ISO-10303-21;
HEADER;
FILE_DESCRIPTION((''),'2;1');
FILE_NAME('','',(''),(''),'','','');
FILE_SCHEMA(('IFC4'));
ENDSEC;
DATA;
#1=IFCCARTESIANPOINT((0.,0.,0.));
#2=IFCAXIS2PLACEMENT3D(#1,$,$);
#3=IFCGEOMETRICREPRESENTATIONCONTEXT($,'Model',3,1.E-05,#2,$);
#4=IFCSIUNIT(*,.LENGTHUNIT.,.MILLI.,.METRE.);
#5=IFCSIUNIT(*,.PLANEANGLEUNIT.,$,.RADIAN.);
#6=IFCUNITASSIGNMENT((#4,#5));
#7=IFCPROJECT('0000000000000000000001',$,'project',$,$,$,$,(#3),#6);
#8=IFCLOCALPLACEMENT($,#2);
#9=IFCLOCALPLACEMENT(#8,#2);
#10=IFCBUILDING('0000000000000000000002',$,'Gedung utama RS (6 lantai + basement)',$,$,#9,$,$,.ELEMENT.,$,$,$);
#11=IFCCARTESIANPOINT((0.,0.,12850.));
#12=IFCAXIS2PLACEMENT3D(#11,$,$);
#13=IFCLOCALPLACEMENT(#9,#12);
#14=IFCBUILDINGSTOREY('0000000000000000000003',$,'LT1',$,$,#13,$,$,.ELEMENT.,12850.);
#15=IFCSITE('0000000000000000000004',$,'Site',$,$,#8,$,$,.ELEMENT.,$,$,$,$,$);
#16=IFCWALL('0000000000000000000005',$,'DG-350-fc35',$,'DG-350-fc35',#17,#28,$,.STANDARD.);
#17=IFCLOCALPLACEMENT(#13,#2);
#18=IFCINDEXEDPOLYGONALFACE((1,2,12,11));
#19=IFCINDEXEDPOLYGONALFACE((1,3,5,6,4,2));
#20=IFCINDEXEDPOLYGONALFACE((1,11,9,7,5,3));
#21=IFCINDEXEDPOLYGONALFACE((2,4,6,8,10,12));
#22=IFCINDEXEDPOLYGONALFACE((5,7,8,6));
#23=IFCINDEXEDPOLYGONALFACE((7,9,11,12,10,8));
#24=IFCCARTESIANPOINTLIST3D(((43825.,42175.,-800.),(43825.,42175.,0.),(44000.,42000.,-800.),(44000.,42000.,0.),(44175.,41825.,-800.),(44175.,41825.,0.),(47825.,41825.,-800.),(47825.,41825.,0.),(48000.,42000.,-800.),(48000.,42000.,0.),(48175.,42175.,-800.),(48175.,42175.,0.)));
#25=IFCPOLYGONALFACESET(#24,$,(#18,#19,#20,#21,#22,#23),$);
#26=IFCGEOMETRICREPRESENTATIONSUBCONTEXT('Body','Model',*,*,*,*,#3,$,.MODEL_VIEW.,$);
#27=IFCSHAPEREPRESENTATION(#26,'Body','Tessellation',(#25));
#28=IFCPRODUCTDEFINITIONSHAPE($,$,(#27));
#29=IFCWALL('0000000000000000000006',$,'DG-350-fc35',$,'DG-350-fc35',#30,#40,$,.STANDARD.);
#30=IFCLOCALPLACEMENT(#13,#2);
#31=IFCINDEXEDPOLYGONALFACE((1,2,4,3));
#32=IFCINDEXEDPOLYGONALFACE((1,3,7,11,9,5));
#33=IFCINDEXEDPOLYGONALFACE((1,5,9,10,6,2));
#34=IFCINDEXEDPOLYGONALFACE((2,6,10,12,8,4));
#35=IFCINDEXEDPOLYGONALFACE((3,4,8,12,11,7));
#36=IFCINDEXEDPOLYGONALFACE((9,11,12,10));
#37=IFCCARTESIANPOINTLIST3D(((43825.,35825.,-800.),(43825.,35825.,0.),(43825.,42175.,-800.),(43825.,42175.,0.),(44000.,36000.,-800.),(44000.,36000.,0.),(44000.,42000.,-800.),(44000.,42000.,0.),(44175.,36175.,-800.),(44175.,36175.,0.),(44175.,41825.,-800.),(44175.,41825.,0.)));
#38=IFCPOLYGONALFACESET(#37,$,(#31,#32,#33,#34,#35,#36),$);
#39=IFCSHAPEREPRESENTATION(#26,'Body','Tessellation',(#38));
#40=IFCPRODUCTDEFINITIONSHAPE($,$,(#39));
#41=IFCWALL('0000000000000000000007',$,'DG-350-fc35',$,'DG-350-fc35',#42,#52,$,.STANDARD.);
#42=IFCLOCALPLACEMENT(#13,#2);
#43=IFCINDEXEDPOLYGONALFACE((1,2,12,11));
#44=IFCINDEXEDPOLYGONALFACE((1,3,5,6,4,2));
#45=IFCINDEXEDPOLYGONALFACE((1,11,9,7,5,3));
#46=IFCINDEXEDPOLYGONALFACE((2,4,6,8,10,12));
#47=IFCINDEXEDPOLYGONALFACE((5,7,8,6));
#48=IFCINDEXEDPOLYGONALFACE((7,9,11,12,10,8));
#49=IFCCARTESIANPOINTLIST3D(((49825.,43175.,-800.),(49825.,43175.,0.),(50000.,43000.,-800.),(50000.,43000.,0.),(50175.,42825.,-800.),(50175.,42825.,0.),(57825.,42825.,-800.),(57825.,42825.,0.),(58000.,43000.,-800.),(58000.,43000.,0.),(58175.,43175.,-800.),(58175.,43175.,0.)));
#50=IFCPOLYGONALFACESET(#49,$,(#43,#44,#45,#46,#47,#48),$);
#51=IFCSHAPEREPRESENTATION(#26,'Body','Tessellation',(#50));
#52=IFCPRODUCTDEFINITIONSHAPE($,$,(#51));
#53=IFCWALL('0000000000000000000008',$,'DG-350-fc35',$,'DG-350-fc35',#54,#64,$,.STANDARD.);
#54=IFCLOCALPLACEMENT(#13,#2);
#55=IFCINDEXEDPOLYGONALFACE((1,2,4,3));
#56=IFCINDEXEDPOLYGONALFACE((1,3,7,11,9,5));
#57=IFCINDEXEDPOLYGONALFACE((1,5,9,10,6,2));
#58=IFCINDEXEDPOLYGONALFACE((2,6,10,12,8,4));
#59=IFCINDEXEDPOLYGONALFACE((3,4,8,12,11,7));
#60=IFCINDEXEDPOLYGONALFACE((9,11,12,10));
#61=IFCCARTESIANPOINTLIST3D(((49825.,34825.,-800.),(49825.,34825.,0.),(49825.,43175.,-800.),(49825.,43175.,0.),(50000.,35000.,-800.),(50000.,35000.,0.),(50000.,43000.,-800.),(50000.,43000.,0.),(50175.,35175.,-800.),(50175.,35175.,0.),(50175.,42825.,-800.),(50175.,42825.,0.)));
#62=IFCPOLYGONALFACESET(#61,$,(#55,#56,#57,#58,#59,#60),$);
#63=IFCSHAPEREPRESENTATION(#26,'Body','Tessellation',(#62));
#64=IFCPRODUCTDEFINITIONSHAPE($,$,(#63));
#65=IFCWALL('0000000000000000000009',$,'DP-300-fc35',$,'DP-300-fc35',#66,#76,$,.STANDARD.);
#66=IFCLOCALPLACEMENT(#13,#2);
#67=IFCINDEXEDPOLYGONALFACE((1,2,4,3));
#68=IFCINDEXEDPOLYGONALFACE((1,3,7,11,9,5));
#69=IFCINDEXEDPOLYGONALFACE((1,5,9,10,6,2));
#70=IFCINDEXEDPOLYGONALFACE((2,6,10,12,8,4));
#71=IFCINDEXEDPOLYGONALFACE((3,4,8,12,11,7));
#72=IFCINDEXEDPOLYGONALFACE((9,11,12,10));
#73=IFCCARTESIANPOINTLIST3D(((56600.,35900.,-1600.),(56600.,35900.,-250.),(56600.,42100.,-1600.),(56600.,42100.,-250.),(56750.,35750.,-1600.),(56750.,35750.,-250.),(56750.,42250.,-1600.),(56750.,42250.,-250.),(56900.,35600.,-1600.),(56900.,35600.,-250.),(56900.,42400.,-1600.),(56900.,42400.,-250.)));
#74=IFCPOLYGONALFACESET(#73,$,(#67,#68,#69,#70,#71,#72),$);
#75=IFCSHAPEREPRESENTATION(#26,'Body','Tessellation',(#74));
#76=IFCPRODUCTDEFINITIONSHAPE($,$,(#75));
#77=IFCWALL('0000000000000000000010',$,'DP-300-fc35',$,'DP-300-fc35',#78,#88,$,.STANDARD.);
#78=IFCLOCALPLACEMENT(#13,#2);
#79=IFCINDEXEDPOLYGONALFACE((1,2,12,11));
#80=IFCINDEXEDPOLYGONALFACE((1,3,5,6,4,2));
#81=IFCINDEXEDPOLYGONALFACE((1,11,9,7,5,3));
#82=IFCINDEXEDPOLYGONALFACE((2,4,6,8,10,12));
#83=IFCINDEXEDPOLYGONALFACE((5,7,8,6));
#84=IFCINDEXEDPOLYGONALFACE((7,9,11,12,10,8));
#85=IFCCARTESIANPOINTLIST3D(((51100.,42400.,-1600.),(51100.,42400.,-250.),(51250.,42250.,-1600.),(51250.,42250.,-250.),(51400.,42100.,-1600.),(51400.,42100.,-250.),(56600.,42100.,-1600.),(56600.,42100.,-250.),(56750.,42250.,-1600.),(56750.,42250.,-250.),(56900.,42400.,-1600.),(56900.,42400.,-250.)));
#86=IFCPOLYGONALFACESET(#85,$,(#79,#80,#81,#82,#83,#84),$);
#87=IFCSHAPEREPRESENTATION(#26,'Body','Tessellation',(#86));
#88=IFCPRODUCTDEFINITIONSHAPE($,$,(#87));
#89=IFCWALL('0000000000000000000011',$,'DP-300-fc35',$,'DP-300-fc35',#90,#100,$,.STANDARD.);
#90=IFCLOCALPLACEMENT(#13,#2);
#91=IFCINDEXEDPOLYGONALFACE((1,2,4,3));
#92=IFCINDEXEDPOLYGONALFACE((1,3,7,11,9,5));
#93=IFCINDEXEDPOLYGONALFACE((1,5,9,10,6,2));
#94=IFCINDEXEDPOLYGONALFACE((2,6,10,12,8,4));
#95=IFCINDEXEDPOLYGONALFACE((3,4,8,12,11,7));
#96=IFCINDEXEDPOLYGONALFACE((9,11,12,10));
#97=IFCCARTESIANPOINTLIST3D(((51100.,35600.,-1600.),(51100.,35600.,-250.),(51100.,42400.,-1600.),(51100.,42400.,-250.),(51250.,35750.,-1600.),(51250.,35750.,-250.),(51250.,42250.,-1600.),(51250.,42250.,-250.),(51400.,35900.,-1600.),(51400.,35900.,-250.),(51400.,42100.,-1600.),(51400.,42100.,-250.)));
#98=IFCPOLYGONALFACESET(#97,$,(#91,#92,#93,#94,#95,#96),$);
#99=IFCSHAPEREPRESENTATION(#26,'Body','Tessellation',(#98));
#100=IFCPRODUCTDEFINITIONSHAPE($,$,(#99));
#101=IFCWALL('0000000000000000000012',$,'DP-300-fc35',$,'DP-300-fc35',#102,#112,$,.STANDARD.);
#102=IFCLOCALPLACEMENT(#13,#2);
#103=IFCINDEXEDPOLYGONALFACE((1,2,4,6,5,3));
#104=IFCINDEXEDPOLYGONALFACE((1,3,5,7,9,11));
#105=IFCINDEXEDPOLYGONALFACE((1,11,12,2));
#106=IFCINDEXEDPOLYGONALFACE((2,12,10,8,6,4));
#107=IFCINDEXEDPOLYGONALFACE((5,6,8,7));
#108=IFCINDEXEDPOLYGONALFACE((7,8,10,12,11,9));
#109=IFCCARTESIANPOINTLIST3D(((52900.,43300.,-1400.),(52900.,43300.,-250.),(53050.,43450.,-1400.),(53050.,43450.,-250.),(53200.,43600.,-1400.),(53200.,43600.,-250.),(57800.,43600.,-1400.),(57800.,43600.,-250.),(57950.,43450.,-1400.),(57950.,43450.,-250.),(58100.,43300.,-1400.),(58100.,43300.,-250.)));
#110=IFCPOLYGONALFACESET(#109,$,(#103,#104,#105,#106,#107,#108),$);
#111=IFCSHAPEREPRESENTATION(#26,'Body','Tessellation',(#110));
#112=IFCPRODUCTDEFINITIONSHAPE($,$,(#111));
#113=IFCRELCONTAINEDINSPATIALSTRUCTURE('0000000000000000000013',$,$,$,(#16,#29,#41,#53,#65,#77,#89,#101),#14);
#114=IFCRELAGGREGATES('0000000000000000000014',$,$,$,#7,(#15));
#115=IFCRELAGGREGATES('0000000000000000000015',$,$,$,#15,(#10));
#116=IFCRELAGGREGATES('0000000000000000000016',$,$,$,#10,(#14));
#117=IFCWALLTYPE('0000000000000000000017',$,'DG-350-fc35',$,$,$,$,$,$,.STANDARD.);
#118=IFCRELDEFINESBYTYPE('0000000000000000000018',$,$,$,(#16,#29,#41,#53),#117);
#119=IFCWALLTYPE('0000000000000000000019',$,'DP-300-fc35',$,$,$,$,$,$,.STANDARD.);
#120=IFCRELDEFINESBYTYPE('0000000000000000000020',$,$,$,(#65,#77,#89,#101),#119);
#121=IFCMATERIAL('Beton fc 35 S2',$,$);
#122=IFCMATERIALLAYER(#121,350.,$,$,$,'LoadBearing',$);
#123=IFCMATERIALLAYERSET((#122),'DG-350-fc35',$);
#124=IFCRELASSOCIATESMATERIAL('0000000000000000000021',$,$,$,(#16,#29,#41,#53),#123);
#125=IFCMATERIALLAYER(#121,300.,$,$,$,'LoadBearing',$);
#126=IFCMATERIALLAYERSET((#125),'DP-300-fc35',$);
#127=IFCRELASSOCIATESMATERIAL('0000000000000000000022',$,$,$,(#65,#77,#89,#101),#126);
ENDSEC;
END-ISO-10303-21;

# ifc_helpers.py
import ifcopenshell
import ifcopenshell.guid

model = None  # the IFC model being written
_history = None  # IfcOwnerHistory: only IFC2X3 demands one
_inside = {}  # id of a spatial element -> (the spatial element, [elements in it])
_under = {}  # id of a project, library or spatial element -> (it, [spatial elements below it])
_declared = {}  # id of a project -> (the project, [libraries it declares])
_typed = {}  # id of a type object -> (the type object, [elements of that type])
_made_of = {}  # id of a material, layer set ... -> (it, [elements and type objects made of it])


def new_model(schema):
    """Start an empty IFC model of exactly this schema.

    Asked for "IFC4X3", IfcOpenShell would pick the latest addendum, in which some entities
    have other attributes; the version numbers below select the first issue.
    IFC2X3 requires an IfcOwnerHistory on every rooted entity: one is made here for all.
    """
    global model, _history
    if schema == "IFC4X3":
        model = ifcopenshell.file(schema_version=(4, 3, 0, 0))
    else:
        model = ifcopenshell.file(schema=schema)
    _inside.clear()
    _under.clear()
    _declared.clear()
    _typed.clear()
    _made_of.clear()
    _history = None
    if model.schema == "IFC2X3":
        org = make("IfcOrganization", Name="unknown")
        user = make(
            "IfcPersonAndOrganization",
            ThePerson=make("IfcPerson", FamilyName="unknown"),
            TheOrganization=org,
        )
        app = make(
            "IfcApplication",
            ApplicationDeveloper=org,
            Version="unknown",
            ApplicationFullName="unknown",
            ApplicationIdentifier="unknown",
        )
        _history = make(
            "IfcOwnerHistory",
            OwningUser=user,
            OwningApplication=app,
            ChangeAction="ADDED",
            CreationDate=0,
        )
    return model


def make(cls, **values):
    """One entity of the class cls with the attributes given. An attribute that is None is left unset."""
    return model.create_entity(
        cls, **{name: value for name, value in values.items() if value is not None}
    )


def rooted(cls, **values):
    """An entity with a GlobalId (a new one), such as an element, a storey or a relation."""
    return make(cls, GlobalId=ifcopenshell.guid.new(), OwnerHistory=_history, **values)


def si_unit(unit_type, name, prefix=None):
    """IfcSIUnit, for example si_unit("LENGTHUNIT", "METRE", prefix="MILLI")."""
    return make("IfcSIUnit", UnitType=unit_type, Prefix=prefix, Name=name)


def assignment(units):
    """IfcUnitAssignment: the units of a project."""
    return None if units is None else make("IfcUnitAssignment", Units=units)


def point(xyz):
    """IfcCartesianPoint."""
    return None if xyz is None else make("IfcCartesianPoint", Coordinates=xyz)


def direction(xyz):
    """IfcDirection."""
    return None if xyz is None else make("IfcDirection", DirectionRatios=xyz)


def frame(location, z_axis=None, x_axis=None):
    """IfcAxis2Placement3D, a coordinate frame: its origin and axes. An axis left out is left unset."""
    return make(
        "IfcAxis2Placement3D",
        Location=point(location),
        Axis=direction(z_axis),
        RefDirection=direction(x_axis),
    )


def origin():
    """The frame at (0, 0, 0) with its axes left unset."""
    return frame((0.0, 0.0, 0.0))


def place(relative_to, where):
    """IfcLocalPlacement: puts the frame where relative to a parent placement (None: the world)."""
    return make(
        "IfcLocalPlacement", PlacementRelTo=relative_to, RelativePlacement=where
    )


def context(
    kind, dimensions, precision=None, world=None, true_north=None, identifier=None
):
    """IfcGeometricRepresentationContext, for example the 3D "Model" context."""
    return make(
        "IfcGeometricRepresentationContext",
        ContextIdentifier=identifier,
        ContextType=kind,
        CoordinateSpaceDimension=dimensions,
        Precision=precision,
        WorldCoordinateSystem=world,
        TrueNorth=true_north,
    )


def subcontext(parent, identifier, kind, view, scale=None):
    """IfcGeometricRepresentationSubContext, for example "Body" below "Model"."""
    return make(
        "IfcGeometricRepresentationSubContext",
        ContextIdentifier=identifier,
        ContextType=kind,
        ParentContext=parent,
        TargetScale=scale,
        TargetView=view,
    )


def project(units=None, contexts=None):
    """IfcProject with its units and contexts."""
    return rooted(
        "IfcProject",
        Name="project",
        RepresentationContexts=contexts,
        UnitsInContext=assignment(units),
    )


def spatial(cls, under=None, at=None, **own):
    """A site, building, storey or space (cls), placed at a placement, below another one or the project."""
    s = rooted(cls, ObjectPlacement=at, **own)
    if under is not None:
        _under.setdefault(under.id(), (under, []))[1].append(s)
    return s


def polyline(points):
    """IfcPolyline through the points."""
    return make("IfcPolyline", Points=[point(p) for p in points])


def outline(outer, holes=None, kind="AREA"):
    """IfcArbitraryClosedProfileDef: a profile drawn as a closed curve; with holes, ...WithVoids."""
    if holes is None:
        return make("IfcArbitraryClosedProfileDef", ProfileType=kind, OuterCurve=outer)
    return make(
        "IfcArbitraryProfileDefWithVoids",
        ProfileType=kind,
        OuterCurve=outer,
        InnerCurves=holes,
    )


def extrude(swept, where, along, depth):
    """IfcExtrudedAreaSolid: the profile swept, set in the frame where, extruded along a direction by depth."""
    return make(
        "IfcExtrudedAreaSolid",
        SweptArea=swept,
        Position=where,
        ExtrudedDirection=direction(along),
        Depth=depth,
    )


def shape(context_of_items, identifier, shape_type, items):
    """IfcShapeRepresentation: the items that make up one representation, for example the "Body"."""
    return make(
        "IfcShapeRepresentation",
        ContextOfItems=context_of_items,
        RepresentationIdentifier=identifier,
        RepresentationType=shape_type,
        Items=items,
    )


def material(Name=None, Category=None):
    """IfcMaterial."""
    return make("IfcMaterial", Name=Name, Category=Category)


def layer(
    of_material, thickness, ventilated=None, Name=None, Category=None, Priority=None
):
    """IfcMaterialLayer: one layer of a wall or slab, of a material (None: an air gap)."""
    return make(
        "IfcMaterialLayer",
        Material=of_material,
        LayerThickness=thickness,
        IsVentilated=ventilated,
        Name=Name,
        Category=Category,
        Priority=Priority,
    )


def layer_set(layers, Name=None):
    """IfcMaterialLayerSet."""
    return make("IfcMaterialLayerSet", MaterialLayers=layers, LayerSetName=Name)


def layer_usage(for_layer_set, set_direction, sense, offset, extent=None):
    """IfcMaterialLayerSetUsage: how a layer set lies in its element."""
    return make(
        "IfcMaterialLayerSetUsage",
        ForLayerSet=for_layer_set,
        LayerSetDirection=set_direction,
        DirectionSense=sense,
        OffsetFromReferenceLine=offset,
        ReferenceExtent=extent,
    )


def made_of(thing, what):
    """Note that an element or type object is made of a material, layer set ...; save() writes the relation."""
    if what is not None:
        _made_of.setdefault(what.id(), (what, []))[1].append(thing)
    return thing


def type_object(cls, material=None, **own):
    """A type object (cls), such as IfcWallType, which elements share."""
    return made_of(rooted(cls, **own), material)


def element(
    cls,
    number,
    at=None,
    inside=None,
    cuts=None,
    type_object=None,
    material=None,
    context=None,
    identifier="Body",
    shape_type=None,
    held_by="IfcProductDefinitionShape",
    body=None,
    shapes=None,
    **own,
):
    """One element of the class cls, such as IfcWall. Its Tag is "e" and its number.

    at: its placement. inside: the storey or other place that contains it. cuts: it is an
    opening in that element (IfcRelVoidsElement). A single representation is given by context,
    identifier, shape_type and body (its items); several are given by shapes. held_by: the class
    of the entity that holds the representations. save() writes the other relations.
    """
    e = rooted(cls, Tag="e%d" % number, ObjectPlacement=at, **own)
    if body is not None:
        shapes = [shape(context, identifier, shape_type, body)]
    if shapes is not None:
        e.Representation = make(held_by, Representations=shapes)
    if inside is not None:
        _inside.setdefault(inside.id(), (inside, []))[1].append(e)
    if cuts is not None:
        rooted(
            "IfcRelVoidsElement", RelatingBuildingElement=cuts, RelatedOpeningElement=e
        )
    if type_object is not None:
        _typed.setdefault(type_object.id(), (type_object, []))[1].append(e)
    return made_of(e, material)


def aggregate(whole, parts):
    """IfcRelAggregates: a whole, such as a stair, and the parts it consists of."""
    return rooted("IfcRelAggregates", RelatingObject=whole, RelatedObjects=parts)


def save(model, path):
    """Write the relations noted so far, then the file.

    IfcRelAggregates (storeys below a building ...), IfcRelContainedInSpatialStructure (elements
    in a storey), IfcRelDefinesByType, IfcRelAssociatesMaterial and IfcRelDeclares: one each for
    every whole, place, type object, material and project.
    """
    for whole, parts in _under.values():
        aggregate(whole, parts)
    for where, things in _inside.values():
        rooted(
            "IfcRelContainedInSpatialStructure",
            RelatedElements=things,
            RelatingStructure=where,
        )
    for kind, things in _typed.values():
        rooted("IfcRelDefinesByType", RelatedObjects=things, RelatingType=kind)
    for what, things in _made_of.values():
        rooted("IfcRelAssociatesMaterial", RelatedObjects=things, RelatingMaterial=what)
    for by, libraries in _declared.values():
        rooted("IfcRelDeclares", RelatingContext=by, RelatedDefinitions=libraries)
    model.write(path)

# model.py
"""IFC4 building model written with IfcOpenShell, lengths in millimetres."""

from ifc_helpers import new_model, si_unit, frame, origin, place, context, subcontext, project, spatial, polyline, outline, extrude, material, layer, layer_set, layer_usage, type_object, element, save


model = new_model("IFC4")

# Units and contexts
model_context = context("Model", 3, precision=1e-05, world=origin())
body_context = subcontext(model_context, "Body", "Model", "MODEL_VIEW")
ifc_project = project(units=[si_unit("LENGTHUNIT", "METRE", prefix="MILLI"), si_unit("PLANEANGLEUNIT", "RADIAN")], contexts=[model_context])

# Site, building, storey
site_placement = place(None, origin())
site = spatial("IfcSite", under=ifc_project, at=site_placement, Name="Site", CompositionType="ELEMENT")
building_placement = place(site_placement, origin())
building = spatial("IfcBuilding", under=site, at=building_placement, Name="Gedung utama RS (6 lantai + basement)", CompositionType="ELEMENT")
storey_placement = place(building_placement, frame((0.0, 0.0, 12850.0)))
storey = spatial("IfcBuildingStorey", under=building, at=storey_placement, Name="LT1", CompositionType="ELEMENT", Elevation=12850.0)

# Shared definitions
ifc_material = material(Name="Beton fc 35 S2")

# Walls
ifc_layer_1 = layer(ifc_material, 350.0, Category="LoadBearing")
ifc_layer_set_1 = layer_set([ifc_layer_1], Name="DG-350-fc35")
ifc_layer_usage_1 = layer_usage(ifc_layer_set_1, "AXIS2", "NEGATIVE", 175.0)
wall_type_1 = type_object("IfcWallType", Name="DG-350-fc35", PredefinedType="STANDARD")
wall_1_placement = place(storey_placement, frame((48000.0, 42000.0, -800.0), z_axis=(0.0, 0.0, 1.0), x_axis=(-1.0, 0.0, 0.0)))
element("IfcWall", 1, at=wall_1_placement, inside=storey, type_object=wall_type_1, material=ifc_layer_usage_1, Name="DG-350-fc35", ObjectType="DG-350-fc35", PredefinedType="STANDARD", context=body_context, shape_type="SweptSolid", body=[
    extrude(outline(polyline([(-175.0, -175.0), (0.0, 0.0), (175.0, 175.0), (3825.0, 175.0), (4000.0, 0.0), (4175.0, -175.0), (-175.0, -175.0)])), origin(), (0.0, 0.0, 1.0), 800.0),
])
wall_2_placement = place(storey_placement, frame((44000.0, 42000.0, -800.0), z_axis=(0.0, 0.0, 1.0), x_axis=(0.0, -1.0, 0.0)))
element("IfcWall", 2, at=wall_2_placement, inside=storey, type_object=wall_type_1, material=ifc_layer_usage_1, Name="DG-350-fc35", ObjectType="DG-350-fc35", PredefinedType="STANDARD", context=body_context, shape_type="SweptSolid", body=[
    extrude(outline(polyline([(-175.0, -175.0), (0.0, 0.0), (175.0, 175.0), (5825.0, 175.0), (6000.0, 0.0), (6175.0, -175.0), (-175.0, -175.0)])), origin(), (0.0, 0.0, 1.0), 800.0),
])
for number, where, z_axis, x_axis, name in (
    (3, (58000.0, 43000.0, -800.0), (0.0, 0.0, 1.0), (-1.0, 0.0, 0.0), "DG-350-fc35"),
    (4, (50000.0, 43000.0, -800.0), (0.0, 0.0, 1.0), (0.0, -1.0, 0.0), "DG-350-fc35"),
):
    element("IfcWall", number, at=place(storey_placement, frame(where, z_axis=z_axis, x_axis=x_axis)), inside=storey, type_object=wall_type_1, material=ifc_layer_usage_1, Name=name, ObjectType="DG-350-fc35", PredefinedType="STANDARD", context=body_context, shape_type="SweptSolid", body=[
        extrude(outline(polyline([(-175.0, -175.0), (0.0, 0.0), (175.0, 175.0), (7825.0, 175.0), (8000.0, 0.0), (8175.0, -175.0), (-175.0, -175.0)])), origin(), (0.0, 0.0, 1.0), 800.0),
    ])
ifc_layer_2 = layer(ifc_material, 300.0, Category="LoadBearing")
ifc_layer_set_2 = layer_set([ifc_layer_2], Name="DP-300-fc35")
ifc_layer_usage_2 = layer_usage(ifc_layer_set_2, "AXIS2", "NEGATIVE", 150.0)
wall_type_2 = type_object("IfcWallType", Name="DP-300-fc35", PredefinedType="STANDARD")
wall_3_placement = place(storey_placement, frame((56750.0, 35750.0, -1600.0), z_axis=(0.0, 0.0, 1.0), x_axis=(0.0, 1.0, 0.0)))
element("IfcWall", 5, at=wall_3_placement, inside=storey, type_object=wall_type_2, material=ifc_layer_usage_2, Name="DP-300-fc35", ObjectType="DP-300-fc35", PredefinedType="STANDARD", context=body_context, shape_type="SweptSolid", body=[
    extrude(outline(polyline([(-150.0, -150.0), (0.0, 0.0), (150.0, 150.0), (6350.0, 150.0), (6500.0, 0.0), (6650.0, -150.0), (-150.0, -150.0)])), origin(), (0.0, 0.0, 1.0), 1350.0),
])
wall_4_placement = place(storey_placement, frame((56750.0, 42250.0, -1600.0), z_axis=(0.0, 0.0, 1.0), x_axis=(-1.0, 0.0, 0.0)))
element("IfcWall", 6, at=wall_4_placement, inside=storey, type_object=wall_type_2, material=ifc_layer_usage_2, Name="DP-300-fc35", ObjectType="DP-300-fc35", PredefinedType="STANDARD", context=body_context, shape_type="SweptSolid", body=[
    extrude(outline(polyline([(-150.0, -150.0), (0.0, 0.0), (150.0, 150.0), (5350.0, 150.0), (5500.0, 0.0), (5650.0, -150.0), (-150.0, -150.0)])), origin(), (0.0, 0.0, 1.0), 1350.0),
])
wall_5_placement = place(storey_placement, frame((51250.0, 42250.0, -1600.0), z_axis=(0.0, 0.0, 1.0), x_axis=(0.0, -1.0, 0.0)))
element("IfcWall", 7, at=wall_5_placement, inside=storey, type_object=wall_type_2, material=ifc_layer_usage_2, Name="DP-300-fc35", ObjectType="DP-300-fc35", PredefinedType="STANDARD", context=body_context, shape_type="SweptSolid", body=[
    extrude(outline(polyline([(-150.0, -150.0), (0.0, 0.0), (150.0, 150.0), (6350.0, 150.0), (6500.0, 0.0), (6650.0, -150.0), (-150.0, -150.0)])), origin(), (0.0, 0.0, 1.0), 1350.0),
])
wall_6_placement = place(storey_placement, frame((53050.0, 43450.0, -1400.0), z_axis=(0.0, 0.0, 1.0), x_axis=(1.0, 0.0, 0.0)))
element("IfcWall", 8, at=wall_6_placement, inside=storey, type_object=wall_type_2, material=ifc_layer_usage_2, Name="DP-300-fc35", ObjectType="DP-300-fc35", PredefinedType="STANDARD", context=body_context, shape_type="SweptSolid", body=[
    extrude(outline(polyline([(-150.0, -150.0), (0.0, 0.0), (150.0, 150.0), (4750.0, 150.0), (4900.0, 0.0), (5050.0, -150.0), (-150.0, -150.0)])), origin(), (0.0, 0.0, 1.0), 1150.0),
])

save(model, "model.ifc")
